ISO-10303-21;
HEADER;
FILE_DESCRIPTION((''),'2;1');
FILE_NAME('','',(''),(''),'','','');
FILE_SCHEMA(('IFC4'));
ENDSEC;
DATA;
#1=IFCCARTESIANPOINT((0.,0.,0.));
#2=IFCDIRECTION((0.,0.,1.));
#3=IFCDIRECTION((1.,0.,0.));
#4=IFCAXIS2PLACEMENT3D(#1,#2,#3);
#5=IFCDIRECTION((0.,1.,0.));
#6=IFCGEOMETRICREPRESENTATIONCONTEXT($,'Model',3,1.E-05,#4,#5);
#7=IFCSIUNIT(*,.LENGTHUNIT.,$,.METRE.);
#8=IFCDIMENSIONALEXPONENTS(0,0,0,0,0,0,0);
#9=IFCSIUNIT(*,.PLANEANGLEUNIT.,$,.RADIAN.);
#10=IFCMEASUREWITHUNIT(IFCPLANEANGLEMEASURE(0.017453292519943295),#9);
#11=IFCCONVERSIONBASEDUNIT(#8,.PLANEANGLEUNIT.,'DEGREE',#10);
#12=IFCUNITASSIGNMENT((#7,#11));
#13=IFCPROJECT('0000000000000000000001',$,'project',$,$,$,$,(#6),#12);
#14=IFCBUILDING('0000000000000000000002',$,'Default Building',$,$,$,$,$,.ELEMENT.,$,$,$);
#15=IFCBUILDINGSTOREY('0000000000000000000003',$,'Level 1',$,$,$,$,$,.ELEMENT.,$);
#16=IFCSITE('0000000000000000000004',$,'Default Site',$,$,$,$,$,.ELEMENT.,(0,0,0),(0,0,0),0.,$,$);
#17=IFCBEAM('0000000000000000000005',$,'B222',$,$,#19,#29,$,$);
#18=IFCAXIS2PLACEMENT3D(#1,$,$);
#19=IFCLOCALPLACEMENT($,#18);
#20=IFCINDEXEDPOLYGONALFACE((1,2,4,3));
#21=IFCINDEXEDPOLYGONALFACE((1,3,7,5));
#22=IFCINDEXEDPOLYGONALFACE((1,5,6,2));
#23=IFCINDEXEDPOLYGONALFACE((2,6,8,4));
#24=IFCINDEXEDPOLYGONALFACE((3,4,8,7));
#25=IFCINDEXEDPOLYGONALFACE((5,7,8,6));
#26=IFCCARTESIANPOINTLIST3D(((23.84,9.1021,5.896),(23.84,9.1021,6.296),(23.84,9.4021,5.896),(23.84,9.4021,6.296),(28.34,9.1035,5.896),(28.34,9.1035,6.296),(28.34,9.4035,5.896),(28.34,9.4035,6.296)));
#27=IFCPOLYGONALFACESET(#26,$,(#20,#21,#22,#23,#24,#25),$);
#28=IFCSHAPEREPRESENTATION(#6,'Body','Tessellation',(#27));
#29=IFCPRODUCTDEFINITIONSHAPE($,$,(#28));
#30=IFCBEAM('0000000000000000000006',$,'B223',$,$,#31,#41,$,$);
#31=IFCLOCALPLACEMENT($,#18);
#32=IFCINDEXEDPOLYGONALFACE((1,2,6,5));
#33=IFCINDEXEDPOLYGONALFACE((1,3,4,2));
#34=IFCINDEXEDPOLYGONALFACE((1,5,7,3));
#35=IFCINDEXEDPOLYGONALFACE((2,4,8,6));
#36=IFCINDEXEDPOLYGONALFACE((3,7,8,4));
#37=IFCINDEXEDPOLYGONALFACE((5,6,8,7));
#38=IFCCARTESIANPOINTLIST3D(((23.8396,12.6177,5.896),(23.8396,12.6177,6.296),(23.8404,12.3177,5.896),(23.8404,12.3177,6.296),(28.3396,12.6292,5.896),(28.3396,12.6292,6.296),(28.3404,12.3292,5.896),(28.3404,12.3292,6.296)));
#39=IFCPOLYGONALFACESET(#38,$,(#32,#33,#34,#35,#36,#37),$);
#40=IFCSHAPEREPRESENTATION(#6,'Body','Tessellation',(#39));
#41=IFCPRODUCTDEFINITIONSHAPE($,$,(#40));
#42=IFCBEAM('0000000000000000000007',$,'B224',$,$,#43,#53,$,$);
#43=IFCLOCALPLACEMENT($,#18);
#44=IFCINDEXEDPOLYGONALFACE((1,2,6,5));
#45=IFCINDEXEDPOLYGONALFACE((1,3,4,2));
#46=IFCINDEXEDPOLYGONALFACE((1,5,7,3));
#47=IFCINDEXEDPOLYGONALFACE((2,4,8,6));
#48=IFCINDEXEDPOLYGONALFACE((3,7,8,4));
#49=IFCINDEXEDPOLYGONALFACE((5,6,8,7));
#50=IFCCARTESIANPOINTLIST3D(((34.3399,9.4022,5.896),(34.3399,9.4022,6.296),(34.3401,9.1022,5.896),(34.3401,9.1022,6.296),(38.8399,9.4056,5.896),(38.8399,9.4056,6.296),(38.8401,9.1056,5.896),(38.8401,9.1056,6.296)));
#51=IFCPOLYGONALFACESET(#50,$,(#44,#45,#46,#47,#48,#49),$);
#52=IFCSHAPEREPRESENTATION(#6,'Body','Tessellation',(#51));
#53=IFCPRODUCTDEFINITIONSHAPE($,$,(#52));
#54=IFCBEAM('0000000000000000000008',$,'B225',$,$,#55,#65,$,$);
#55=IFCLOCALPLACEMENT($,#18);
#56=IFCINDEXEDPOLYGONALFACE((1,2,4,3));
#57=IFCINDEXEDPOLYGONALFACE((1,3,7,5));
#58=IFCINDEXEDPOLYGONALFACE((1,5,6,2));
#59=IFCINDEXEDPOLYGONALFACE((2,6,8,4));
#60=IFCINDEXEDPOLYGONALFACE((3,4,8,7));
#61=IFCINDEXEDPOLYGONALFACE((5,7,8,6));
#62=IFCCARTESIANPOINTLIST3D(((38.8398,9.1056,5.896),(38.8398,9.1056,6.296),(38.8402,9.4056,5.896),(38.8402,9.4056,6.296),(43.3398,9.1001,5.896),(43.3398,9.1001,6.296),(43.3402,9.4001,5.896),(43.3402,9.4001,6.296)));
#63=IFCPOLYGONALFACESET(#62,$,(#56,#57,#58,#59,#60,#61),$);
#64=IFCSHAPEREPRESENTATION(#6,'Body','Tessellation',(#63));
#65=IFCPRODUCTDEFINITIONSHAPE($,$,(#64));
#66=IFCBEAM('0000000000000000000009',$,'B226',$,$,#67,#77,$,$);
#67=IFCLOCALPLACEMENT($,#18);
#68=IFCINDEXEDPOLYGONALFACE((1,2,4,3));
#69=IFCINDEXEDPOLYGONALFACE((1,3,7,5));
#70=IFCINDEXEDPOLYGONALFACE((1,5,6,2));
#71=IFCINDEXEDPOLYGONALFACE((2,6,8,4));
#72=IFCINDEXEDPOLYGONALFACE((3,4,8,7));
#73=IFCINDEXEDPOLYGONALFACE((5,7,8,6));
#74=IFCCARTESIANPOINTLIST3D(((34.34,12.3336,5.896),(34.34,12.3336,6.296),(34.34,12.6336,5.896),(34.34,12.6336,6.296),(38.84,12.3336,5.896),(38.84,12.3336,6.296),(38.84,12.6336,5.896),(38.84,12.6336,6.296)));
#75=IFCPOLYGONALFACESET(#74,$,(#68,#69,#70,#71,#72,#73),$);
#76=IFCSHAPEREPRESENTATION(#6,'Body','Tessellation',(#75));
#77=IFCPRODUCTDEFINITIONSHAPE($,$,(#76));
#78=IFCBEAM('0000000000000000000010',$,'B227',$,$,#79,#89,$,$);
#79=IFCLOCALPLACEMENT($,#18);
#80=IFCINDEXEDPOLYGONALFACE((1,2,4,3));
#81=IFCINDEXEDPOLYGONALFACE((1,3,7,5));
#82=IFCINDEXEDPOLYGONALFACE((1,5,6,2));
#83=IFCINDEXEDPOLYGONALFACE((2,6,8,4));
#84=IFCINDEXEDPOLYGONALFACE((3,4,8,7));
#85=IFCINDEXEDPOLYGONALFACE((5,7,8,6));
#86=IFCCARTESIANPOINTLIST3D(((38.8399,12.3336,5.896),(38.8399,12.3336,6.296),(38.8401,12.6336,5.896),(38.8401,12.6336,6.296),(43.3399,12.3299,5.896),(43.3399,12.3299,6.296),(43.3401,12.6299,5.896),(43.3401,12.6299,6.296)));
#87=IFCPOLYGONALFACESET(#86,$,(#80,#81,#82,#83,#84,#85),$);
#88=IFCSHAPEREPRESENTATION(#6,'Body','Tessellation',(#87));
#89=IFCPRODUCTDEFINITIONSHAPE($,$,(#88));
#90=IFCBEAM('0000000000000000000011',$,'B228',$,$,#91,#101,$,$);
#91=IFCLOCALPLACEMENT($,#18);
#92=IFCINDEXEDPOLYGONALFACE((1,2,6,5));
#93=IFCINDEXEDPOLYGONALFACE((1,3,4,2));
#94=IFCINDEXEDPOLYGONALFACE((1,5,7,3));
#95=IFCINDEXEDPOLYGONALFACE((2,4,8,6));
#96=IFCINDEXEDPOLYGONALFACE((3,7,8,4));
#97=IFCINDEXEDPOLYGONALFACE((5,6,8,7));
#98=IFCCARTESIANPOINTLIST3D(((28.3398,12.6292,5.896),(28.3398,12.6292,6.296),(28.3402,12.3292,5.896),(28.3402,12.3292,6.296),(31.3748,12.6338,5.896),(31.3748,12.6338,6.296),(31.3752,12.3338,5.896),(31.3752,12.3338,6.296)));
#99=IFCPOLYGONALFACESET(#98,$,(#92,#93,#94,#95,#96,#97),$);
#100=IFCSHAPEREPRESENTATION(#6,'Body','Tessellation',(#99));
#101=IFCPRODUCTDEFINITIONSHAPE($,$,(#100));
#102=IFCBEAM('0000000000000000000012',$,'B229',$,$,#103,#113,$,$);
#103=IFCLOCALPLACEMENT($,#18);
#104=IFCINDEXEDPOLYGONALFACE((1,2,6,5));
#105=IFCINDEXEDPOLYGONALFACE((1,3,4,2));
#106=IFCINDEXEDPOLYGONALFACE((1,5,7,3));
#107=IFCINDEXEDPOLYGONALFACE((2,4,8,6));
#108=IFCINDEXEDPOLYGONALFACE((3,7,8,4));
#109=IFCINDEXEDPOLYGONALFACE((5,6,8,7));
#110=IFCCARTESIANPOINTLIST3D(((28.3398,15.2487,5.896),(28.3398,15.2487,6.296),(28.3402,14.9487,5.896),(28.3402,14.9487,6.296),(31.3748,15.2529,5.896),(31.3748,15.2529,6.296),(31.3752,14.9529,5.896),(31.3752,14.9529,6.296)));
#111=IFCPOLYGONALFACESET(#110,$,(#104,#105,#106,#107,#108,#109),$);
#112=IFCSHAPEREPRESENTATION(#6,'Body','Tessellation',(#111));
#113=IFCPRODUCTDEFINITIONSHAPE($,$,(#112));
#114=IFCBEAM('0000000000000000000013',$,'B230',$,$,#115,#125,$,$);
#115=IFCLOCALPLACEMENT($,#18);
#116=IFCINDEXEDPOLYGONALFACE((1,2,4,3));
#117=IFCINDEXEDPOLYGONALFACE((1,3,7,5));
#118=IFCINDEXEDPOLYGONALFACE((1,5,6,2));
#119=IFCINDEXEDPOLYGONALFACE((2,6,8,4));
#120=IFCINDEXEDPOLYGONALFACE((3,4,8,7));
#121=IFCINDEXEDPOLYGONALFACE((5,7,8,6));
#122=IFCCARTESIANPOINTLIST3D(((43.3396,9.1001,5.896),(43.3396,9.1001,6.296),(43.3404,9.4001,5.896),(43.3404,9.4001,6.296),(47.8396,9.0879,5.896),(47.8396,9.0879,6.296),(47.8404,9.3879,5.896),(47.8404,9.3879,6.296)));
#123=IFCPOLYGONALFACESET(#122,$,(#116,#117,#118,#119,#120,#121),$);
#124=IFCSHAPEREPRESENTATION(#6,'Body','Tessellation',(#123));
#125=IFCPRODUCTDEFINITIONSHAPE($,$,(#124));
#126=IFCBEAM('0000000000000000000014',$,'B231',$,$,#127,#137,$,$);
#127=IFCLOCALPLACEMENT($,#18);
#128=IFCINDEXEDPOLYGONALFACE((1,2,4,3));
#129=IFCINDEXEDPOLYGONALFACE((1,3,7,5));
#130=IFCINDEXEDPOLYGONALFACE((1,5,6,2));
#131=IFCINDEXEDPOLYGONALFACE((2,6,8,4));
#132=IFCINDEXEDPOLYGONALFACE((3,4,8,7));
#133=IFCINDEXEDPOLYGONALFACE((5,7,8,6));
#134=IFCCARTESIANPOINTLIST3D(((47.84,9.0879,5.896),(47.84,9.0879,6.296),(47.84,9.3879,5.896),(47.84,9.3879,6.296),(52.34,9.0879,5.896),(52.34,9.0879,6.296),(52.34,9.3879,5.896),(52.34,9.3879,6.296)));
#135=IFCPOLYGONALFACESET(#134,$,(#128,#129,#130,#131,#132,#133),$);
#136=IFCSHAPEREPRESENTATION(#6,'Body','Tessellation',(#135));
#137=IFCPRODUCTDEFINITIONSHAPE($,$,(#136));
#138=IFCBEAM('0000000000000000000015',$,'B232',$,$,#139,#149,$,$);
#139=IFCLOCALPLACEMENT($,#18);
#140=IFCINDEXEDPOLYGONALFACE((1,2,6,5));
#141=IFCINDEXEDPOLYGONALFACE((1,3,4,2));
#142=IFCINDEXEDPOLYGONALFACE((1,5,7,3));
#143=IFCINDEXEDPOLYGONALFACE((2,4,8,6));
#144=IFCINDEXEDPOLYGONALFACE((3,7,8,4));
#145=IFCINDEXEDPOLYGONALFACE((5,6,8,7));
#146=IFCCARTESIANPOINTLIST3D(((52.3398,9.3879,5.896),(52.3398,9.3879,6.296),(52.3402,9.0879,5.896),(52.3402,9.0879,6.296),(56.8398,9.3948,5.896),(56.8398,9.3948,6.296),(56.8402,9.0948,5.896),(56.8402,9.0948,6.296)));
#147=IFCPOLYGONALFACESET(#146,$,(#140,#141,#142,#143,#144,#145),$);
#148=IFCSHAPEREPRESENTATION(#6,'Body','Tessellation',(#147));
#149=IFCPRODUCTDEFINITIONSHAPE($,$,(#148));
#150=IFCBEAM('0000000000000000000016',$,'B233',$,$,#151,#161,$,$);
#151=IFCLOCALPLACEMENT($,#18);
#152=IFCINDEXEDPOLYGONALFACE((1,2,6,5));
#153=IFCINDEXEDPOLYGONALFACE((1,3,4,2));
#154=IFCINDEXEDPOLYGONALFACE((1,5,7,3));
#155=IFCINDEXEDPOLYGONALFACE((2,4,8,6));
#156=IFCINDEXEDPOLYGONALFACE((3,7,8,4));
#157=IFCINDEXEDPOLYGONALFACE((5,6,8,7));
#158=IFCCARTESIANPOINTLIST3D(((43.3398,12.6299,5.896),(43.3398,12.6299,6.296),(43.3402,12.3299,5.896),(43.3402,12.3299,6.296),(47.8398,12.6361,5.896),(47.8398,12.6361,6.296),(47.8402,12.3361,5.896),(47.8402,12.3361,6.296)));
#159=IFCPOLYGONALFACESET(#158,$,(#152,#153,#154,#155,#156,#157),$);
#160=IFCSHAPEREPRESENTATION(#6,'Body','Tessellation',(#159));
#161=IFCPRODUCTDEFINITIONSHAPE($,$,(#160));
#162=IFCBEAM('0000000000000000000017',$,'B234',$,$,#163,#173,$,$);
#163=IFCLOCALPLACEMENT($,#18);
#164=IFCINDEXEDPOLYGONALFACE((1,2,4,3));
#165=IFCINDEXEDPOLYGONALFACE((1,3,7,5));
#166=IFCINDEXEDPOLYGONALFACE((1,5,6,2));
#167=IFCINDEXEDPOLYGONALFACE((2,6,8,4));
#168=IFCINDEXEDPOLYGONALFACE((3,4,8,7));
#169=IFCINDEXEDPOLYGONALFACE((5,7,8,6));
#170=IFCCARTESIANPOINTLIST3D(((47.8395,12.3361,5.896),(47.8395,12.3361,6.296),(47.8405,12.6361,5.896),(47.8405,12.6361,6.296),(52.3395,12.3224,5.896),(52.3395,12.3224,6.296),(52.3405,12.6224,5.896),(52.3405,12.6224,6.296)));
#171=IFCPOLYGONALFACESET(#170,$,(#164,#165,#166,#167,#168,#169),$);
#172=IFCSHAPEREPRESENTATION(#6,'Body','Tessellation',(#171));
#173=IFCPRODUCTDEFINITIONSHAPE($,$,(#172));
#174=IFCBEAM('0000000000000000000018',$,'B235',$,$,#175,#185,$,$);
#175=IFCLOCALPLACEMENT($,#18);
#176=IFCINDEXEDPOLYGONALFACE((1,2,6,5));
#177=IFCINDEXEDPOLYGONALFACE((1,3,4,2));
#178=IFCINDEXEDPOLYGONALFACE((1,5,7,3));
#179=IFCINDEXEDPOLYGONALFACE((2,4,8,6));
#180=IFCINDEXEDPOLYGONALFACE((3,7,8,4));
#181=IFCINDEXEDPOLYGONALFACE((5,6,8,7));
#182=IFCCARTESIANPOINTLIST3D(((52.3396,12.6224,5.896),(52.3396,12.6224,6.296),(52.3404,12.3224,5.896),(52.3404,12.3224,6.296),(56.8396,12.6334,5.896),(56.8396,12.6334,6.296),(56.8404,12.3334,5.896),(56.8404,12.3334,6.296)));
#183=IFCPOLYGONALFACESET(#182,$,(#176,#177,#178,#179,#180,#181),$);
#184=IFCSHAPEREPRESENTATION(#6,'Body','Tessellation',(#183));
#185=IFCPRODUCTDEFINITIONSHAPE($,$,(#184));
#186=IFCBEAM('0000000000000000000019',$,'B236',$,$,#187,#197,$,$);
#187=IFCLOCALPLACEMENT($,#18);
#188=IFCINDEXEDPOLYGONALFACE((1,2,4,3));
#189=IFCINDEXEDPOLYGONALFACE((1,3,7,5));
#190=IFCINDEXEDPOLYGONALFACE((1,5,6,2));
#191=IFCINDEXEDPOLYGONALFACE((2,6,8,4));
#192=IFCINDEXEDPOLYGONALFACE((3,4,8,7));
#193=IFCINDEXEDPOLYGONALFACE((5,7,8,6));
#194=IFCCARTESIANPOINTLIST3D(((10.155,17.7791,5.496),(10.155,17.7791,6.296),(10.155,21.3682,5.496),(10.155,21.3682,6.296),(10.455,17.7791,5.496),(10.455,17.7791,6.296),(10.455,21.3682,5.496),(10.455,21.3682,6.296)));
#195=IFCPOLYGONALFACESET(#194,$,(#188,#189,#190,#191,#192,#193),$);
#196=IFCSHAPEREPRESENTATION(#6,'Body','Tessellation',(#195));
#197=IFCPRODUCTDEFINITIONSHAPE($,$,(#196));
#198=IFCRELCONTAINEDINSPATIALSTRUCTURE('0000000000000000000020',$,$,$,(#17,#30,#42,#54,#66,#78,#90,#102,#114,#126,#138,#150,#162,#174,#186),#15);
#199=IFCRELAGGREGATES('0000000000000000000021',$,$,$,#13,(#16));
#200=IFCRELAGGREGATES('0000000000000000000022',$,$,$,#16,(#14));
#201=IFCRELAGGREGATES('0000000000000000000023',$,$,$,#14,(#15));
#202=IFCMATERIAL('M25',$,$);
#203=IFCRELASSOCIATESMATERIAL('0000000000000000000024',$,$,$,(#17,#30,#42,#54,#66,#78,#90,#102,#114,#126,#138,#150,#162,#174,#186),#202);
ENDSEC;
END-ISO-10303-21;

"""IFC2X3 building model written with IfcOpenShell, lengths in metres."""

from ifc_helpers import new_model, entity, si_unit, converted_unit, direction, frame, frame_2d, origin_with_axes, place, context, project, spatial, rectangle, extrude, material, element, save


model = new_model("IFC2X3")

# Units and contexts
model_context = context("Model", 3, precision=1e-05, world=origin_with_axes(), true_north=direction((0.0, 1.0, 0.0)))
ifc_project = project(units=[si_unit("LENGTHUNIT", "METRE"), converted_unit("PLANEANGLEUNIT", "DEGREE", entity("IfcPlaneAngleMeasure", 0.017453292519943295), si_unit("PLANEANGLEUNIT", "RADIAN"), dimensions=[0, 0, 0, 0, 0, 0, 0])], contexts=[model_context])

# Site, building, storey
site = spatial("IfcSite", under=ifc_project, Name="Default Site", CompositionType="ELEMENT", RefLatitude=(0, 0, 0), RefLongitude=(0, 0, 0), RefElevation=0.0)
building = spatial("IfcBuilding", under=site, Name="Default Building", CompositionType="ELEMENT")
storey = spatial("IfcBuildingStorey", under=building, Name="Level 1", CompositionType="ELEMENT")

# Beams
ifc_material = material(Name="M25")
placement = place(None, origin_with_axes())
element("IfcBeam", 1, at=placement, inside=storey, material=ifc_material, Name="B222", context=model_context, shape_type="SweptSolid", body=[
    extrude(rectangle(XDim=0.3, YDim=0.4, at=frame_2d((0.0, 0.0), x_axis=(0.0, 1.0, 0.0))), frame((23.84, 9.2521, 6.096), z_axis=(1.0, 0.000307, 0.0), x_axis=(0.0, 0.0, -1.0)), (0.0, 0.0, 1.0), 4.5),
])
element("IfcBeam", 2, at=placement, inside=storey, material=ifc_material, Name="B223", context=model_context, shape_type="SweptSolid", body=[
    extrude(rectangle(XDim=0.3, YDim=0.4, at=frame_2d((0.0, 0.0), x_axis=(0.0, 1.0, 0.0))), frame((23.84, 12.4677, 6.096), z_axis=(0.999997, 0.002551, 0.0), x_axis=(0.0, 0.0, -1.0)), (0.0, 0.0, 1.0), 4.5),
])
element("IfcBeam", 3, at=placement, inside=storey, material=ifc_material, Name="B224", context=model_context, shape_type="SweptSolid", body=[
    extrude(rectangle(XDim=0.3, YDim=0.4, at=frame_2d((0.0, 0.0), x_axis=(0.0, 1.0, 0.0))), frame((34.34, 9.2522, 6.096), z_axis=(1.0, 0.000748, 0.0), x_axis=(0.0, 0.0, -1.0)), (0.0, 0.0, 1.0), 4.5),
])
element("IfcBeam", 4, at=placement, inside=storey, material=ifc_material, Name="B225", context=model_context, shape_type="SweptSolid", body=[
    extrude(rectangle(XDim=0.3, YDim=0.4, at=frame_2d((0.0, 0.0), x_axis=(0.0, 1.0, 0.0))), frame((38.84, 9.2556, 6.096), z_axis=(0.999999, -0.001227, 0.0), x_axis=(0.0, 0.0, -1.0)), (0.0, 0.0, 1.0), 4.5),
])
element("IfcBeam", 5, at=placement, inside=storey, material=ifc_material, Name="B226", context=model_context, shape_type="SweptSolid", body=[
    extrude(rectangle(XDim=0.3, YDim=0.4, at=frame_2d((0.0, 0.0), x_axis=(0.0, 1.0, 0.0))), frame((34.34, 12.4836, 6.096), z_axis=(1.0, -0.000008, 0.0), x_axis=(0.0, 0.0, -1.0)), (0.0, 0.0, 1.0), 4.5),
])
element("IfcBeam", 6, at=placement, inside=storey, material=ifc_material, Name="B227", context=model_context, shape_type="SweptSolid", body=[
    extrude(rectangle(XDim=0.3, YDim=0.4, at=frame_2d((0.0, 0.0), x_axis=(0.0, 1.0, 0.0))), frame((38.84, 12.4836, 6.096), z_axis=(1.0, -0.000826, 0.0), x_axis=(0.0, 0.0, -1.0)), (0.0, 0.0, 1.0), 4.5),
])
element("IfcBeam", 7, at=placement, inside=storey, material=ifc_material, Name="B228", context=model_context, shape_type="SweptSolid", body=[
    extrude(rectangle(XDim=0.3, YDim=0.4, at=frame_2d((0.0, 0.0), x_axis=(0.0, 1.0, 0.0))), frame((28.34, 12.4792, 6.096), z_axis=(0.999999, 0.001542, 0.0), x_axis=(0.0, 0.0, -1.0)), (0.0, 0.0, 1.0), 3.035),
])
element("IfcBeam", 8, at=placement, inside=storey, material=ifc_material, Name="B229", context=model_context, shape_type="SweptSolid", body=[
    extrude(rectangle(XDim=0.3, YDim=0.4, at=frame_2d((0.0, 0.0), x_axis=(0.0, 1.0, 0.0))), frame((31.375, 15.1029, 6.096), z_axis=(-0.999999, -0.001391, 0.0), x_axis=(0.0, 0.0, -1.0)), (0.0, 0.0, 1.0), 3.035),
])
element("IfcBeam", 9, at=placement, inside=storey, material=ifc_material, Name="B230", context=model_context, shape_type="SweptSolid", body=[
    extrude(rectangle(XDim=0.3, YDim=0.4, at=frame_2d((0.0, 0.0), x_axis=(0.0, 1.0, 0.0))), frame((43.34, 9.2501, 6.096), z_axis=(0.999996, -0.002702, 0.0), x_axis=(0.0, 0.0, -1.0)), (0.0, 0.0, 1.0), 4.5),
])
element("IfcBeam", 10, at=placement, inside=storey, material=ifc_material, Name="B231", context=model_context, shape_type="SweptSolid", body=[
    extrude(rectangle(XDim=0.3, YDim=0.4, at=frame_2d((0.0, 0.0), x_axis=(0.0, 1.0, 0.0))), frame((47.84, 9.2379, 6.096), z_axis=(1.0, 0.0, 0.0), x_axis=(0.0, 0.0, -1.0)), (0.0, 0.0, 1.0), 4.5),
])
element("IfcBeam", 11, at=placement, inside=storey, material=ifc_material, Name="B232", context=model_context, shape_type="SweptSolid", body=[
    extrude(rectangle(XDim=0.3, YDim=0.4, at=frame_2d((0.0, 0.0), x_axis=(0.0, 1.0, 0.0))), frame((52.34, 9.2379, 6.096), z_axis=(0.999999, 0.001537, 0.0), x_axis=(0.0, 0.0, -1.0)), (0.0, 0.0, 1.0), 4.5),
])
element("IfcBeam", 12, at=placement, inside=storey, material=ifc_material, Name="B233", context=model_context, shape_type="SweptSolid", body=[
    extrude(rectangle(XDim=0.3, YDim=0.4, at=frame_2d((0.0, 0.0), x_axis=(0.0, 1.0, 0.0))), frame((43.34, 12.4799, 6.096), z_axis=(0.999999, 0.001374, 0.0), x_axis=(0.0, 0.0, -1.0)), (0.0, 0.0, 1.0), 4.5),
])
element("IfcBeam", 13, at=placement, inside=storey, material=ifc_material, Name="B234", context=model_context, shape_type="SweptSolid", body=[
    extrude(rectangle(XDim=0.3, YDim=0.4, at=frame_2d((0.0, 0.0), x_axis=(0.0, 1.0, 0.0))), frame((47.84, 12.4861, 6.096), z_axis=(0.999995, -0.003045, 0.0), x_axis=(0.0, 0.0, -1.0)), (0.0, 0.0, 1.0), 4.5),
])
element("IfcBeam", 14, at=placement, inside=storey, material=ifc_material, Name="B235", context=model_context, shape_type="SweptSolid", body=[
    extrude(rectangle(XDim=0.3, YDim=0.4, at=frame_2d((0.0, 0.0), x_axis=(0.0, 1.0, 0.0))), frame((52.34, 12.4724, 6.096), z_axis=(0.999997, 0.002456, 0.0), x_axis=(0.0, 0.0, -1.0)), (0.0, 0.0, 1.0), 4.5),
])
element("IfcBeam", 15, at=placement, inside=storey, material=ifc_material, Name="B236", context=model_context, shape_type="SweptSolid", body=[
    extrude(rectangle(XDim=0.3, YDim=0.8, at=frame_2d((0.0, 0.0), x_axis=(0.0, 1.0, 0.0))), frame((10.305, 21.3682, 5.896), z_axis=(0.0, -1.0, 0.0), x_axis=(0.0, 0.0, -1.0)), (0.0, 0.0, 1.0), 3.5891),
])

save(model, "model.ifc")
